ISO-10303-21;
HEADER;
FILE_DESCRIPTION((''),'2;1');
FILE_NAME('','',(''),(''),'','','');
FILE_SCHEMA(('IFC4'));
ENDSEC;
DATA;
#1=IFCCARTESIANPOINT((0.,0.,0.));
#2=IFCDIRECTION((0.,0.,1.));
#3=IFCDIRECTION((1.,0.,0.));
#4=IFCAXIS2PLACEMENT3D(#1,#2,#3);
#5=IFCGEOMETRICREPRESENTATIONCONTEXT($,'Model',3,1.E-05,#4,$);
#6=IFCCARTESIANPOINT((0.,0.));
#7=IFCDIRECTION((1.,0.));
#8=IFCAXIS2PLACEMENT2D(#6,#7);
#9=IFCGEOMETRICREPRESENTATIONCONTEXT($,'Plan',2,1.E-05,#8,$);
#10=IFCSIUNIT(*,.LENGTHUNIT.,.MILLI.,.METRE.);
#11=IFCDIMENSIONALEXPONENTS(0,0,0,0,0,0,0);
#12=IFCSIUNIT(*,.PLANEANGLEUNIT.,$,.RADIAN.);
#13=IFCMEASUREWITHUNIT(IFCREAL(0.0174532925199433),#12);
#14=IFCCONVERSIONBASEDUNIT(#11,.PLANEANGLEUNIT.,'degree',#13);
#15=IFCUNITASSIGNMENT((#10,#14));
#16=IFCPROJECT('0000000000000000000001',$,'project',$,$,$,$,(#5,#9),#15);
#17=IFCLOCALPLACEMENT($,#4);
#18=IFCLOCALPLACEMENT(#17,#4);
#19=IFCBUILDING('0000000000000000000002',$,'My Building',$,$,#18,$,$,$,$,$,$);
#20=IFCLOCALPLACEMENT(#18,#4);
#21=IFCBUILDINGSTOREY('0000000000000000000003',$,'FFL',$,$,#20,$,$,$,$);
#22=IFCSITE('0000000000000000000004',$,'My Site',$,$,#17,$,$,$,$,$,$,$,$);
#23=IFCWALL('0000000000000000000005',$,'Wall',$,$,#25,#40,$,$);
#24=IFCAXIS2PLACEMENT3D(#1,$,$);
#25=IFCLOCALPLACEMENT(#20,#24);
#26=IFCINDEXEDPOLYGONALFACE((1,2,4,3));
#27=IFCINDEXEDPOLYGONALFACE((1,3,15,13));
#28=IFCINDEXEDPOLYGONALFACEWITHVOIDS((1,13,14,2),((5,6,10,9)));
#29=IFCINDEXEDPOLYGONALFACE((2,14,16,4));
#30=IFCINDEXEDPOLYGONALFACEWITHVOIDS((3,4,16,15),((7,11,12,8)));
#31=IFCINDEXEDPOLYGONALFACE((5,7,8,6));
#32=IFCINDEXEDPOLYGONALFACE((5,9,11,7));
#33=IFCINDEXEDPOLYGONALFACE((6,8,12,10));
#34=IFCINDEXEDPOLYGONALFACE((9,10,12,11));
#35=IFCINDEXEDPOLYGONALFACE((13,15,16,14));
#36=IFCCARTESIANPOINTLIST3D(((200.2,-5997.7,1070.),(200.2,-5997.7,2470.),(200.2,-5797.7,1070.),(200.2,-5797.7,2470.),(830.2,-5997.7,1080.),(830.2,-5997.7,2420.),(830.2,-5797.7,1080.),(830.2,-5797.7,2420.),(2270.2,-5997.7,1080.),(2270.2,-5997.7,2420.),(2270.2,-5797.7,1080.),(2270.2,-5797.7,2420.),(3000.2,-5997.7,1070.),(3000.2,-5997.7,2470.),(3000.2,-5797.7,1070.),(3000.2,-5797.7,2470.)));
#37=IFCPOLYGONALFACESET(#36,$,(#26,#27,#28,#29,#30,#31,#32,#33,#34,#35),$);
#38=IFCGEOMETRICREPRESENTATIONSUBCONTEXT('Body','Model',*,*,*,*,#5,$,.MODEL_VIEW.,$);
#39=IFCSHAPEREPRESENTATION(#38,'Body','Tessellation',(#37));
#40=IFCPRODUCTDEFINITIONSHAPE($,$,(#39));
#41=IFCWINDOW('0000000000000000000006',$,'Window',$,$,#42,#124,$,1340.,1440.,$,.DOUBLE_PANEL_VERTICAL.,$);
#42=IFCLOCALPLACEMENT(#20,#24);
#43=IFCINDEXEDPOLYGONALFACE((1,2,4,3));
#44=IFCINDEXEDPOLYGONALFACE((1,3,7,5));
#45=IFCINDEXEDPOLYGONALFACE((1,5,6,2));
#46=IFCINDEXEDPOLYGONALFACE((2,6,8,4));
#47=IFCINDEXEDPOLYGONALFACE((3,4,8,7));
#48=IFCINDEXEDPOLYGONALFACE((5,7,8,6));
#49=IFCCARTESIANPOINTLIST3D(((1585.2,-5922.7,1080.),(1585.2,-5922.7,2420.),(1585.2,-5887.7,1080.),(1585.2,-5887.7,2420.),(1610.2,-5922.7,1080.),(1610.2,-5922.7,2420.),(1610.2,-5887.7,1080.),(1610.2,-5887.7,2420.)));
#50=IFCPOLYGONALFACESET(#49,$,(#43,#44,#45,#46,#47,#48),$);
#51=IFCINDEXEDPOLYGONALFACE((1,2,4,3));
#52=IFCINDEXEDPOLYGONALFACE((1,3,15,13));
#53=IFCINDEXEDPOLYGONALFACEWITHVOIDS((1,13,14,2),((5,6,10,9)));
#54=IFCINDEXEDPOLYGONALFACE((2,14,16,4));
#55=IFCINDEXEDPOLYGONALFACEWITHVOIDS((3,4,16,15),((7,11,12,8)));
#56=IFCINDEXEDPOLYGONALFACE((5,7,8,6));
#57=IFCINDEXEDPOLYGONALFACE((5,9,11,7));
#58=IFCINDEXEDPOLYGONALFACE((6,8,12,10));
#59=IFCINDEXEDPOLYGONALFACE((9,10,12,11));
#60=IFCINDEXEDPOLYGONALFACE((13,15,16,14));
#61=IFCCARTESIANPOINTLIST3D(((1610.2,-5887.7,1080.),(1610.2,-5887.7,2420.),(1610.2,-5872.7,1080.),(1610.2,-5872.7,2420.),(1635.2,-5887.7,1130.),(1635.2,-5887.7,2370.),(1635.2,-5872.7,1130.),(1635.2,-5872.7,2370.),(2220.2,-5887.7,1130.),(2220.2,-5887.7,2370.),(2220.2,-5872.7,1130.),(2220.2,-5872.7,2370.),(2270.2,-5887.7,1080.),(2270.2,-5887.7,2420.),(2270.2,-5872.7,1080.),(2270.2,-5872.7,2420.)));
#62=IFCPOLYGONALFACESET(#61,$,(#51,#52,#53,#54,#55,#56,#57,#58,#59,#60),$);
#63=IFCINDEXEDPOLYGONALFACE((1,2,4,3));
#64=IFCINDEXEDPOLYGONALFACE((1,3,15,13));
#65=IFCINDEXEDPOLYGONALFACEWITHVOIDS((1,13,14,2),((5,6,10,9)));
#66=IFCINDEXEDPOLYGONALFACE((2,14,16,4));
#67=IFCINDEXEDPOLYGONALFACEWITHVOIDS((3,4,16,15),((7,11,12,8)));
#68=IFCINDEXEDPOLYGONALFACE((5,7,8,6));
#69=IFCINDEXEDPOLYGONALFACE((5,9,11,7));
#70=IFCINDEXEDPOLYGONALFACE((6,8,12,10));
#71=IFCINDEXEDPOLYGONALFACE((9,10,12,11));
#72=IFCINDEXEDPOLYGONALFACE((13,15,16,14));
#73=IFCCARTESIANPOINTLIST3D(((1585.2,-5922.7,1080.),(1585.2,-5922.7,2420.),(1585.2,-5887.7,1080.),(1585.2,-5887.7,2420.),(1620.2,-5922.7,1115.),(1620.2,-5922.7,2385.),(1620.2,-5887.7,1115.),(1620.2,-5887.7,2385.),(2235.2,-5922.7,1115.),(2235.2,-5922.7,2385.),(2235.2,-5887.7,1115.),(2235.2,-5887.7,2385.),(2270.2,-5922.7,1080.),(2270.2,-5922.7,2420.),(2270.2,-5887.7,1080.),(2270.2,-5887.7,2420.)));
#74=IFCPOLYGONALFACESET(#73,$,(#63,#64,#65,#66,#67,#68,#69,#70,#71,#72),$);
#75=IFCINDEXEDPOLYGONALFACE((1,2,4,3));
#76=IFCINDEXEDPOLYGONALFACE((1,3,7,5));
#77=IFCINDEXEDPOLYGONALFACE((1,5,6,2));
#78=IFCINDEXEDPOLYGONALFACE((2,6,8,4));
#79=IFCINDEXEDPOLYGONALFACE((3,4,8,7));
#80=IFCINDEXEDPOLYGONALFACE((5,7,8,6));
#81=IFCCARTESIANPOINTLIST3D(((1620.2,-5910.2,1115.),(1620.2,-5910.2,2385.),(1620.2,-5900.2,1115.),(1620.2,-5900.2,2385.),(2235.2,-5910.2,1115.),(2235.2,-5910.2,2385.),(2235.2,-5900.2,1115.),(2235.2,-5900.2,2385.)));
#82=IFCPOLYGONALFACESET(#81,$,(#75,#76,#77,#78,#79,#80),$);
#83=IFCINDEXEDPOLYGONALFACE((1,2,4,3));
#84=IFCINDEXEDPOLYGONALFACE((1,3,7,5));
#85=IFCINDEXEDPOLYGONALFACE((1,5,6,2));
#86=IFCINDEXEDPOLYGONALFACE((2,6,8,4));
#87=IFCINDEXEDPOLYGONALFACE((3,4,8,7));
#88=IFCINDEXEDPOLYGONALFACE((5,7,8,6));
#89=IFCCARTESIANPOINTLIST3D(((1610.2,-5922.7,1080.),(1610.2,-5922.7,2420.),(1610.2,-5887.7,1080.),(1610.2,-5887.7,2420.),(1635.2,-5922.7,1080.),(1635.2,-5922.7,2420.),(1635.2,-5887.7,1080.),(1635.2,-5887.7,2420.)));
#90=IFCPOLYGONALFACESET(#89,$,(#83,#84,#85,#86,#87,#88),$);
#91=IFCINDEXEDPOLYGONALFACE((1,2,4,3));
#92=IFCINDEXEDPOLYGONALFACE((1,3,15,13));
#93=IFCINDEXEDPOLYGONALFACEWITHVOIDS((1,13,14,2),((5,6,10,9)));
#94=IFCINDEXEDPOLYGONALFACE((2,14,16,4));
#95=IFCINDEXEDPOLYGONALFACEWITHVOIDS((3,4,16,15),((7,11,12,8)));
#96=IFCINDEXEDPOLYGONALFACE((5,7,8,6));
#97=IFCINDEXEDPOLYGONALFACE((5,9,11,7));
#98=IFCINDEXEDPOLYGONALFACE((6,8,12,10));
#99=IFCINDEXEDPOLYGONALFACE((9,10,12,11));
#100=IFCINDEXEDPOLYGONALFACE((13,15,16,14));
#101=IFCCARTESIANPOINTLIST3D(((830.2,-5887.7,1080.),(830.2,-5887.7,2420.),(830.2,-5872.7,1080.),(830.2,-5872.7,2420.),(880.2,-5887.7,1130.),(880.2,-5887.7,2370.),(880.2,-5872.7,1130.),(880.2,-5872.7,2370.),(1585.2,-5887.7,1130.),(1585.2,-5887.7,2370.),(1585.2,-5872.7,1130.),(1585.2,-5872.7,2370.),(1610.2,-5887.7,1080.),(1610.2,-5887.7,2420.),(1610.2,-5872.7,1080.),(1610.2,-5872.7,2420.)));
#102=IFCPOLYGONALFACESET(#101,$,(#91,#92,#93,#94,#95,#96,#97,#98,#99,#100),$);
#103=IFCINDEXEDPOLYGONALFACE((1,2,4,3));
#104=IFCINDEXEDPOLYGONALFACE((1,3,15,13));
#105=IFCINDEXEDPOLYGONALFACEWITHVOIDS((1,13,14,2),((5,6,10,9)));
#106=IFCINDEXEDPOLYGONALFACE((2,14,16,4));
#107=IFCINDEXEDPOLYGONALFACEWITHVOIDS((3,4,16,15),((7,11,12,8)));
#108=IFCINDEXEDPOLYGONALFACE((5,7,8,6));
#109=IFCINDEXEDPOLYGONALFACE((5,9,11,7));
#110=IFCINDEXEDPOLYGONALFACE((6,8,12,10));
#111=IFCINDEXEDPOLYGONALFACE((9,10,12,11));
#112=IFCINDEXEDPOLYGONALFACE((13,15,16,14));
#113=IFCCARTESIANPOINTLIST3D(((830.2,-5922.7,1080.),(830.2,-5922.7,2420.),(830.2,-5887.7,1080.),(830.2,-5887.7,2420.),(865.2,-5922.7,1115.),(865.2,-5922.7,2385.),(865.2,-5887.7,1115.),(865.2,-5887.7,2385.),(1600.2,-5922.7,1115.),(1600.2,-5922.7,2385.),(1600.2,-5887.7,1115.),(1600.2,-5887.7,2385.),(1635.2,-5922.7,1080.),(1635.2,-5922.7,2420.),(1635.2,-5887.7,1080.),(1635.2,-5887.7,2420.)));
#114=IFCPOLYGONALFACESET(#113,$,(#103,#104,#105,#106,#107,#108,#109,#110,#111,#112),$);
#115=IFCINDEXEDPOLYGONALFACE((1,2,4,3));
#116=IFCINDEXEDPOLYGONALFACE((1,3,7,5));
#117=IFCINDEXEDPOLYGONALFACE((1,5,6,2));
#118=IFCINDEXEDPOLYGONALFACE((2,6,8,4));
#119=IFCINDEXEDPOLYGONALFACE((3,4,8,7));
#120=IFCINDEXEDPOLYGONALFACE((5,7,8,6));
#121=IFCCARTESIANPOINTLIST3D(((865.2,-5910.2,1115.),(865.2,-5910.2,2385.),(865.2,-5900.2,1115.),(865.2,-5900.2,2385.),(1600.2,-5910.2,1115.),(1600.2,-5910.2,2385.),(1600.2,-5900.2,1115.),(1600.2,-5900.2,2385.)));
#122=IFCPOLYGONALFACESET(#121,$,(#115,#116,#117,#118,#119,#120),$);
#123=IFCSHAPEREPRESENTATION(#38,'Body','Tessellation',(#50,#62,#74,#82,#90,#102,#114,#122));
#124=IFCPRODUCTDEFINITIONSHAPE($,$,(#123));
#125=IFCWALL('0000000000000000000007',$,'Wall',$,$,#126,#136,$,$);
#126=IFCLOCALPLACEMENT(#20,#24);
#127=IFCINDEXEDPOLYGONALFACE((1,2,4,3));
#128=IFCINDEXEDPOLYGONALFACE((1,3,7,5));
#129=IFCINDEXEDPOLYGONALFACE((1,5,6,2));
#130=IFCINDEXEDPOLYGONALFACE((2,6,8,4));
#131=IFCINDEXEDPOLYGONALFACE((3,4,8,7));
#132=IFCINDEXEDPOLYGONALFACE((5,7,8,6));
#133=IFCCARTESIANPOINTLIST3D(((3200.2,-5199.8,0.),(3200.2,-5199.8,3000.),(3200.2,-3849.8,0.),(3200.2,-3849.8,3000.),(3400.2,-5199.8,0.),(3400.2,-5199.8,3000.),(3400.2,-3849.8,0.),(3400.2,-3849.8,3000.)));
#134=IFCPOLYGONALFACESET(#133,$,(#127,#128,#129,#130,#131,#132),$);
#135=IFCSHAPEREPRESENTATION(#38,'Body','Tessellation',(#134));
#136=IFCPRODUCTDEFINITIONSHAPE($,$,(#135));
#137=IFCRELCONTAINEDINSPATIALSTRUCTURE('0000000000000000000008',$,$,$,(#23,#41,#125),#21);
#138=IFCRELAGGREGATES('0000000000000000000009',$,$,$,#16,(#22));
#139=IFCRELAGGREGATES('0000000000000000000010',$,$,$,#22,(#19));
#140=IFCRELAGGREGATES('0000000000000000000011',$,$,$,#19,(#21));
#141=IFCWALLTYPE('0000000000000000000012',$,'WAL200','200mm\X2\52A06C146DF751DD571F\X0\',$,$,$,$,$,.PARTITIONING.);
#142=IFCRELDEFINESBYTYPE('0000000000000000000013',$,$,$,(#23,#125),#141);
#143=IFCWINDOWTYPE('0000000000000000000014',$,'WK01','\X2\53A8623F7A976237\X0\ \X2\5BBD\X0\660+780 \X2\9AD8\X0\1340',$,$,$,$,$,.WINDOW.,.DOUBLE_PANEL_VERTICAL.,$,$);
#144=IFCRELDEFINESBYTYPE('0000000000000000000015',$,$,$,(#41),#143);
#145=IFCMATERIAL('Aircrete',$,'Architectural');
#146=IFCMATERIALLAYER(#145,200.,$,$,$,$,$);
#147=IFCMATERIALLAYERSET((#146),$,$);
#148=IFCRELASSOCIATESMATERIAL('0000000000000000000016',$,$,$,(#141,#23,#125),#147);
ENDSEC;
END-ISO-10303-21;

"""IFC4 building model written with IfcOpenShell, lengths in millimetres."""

from ifc_helpers import new_model, entity, si_unit, converted_unit, frame, origin_with_axes, origin_2d_with_axis, place, context, subcontext, project, spatial, line, indexed_curve, outline, extrude, shape, source, transform, mapped, material, layer, layer_set, layer_usage, type_object, type_shapes, element, fill, save


model = new_model("IFC4")

# Units and contexts
model_context = context("Model", 3, precision=1e-05, world=origin_with_axes())
plan_context = context("Plan", 2, precision=1e-05, world=origin_2d_with_axis())
body_context_1 = subcontext(model_context, "Body", "Model", "MODEL_VIEW")
body_context_2 = subcontext(plan_context, "Body", "Plan", "PLAN_VIEW")
ifc_project = project(units=[si_unit("LENGTHUNIT", "METRE", prefix="MILLI"), converted_unit("PLANEANGLEUNIT", "degree", entity("IfcReal", 0.0174532925199433), si_unit("PLANEANGLEUNIT", "RADIAN"), dimensions=[0, 0, 0, 0, 0, 0, 0])], contexts=[model_context, plan_context])

# Site, building, storey
site_placement = place(None, origin_with_axes())
site = spatial("IfcSite", under=ifc_project, at=site_placement, Name="My Site")
building_placement = place(site_placement, origin_with_axes())
building = spatial("IfcBuilding", under=site, at=building_placement, Name="My Building")
storey_placement = place(building_placement, origin_with_axes())
storey = spatial("IfcBuildingStorey", under=building, at=storey_placement, Name="FFL")

# Shared definitions
ifc_material_1 = material(Name="Aircrete", Category="Architectural")

# Wall, opening, window
ifc_layer_1 = layer(ifc_material_1, 200.0)
ifc_layer_set_1 = layer_set([ifc_layer_1])
ifc_layer_usage_1 = layer_usage(ifc_layer_set_1, "AXIS2", "NEGATIVE", 0.0)
wall_type_1 = type_object("IfcWallType", Name="WAL200", Description="200mm加气混凝土", PredefinedType="PARTITIONING", material=ifc_layer_set_1)
wall_1_placement = place(storey_placement, frame((200.2, -5797.7, 1070.0), z_axis=(0.0, 0.0, 1.0), x_axis=(1.0, 0.0, 0.0)))
wall_1 = element("IfcWall", 1, at=wall_1_placement, inside=storey, type_object=wall_type_1, material=ifc_layer_usage_1, Name="Wall", context=body_context_1, shape_type="SweptSolid", body=[
    extrude(outline(indexed_curve([(0.0, -200.0), (0.0, 0.0), (2800.0, 0.0), (2800.0, -200.0)], segments=[line(1, 2, 3, 4, 1)])), origin_with_axes(), (0.0, 0.0, 1.0), 1400.0),
])
shared_shape_1 = source(origin_with_axes(), body_context_1, "Body", "SweptSolid", [
    extrude(outline(indexed_curve([(0.0, 0.0), (1440.0, 0.0), (1440.0, 1340.0), (0.0, 1340.0)], segments=[line(1, 2, 3, 4, 1)])), frame((0.0, -600.0, 0.0), z_axis=(0.0, -1.0, 0.0), x_axis=(1.0, 0.0, 0.0)), (0.0, 0.0, -1.0), 1200.0),
])
opening_1_placement = place(wall_1_placement, frame((2070.0, -25.0, 10.0), z_axis=(0.0, 0.0, 1.0), x_axis=(-1.0, 0.0, 0.0)))
opening_1 = element("IfcOpeningElement", 2, at=opening_1_placement, cuts=wall_1, PredefinedType="OPENING", context=body_context_1, shape_type="MappedRepresentation", body=[
    mapped(shared_shape_1, transform((0.0, 0.0, 0.0), x_axis=(1.0, 0.0, 0.0), y_axis=(0.0, 1.0, 0.0), z_axis=(0.0, 0.0, 1.0), scale=1.0)),
])
window_type_1 = type_object("IfcWindowType", Name="WK01", Description="厨房窗户 宽660+780 高1340", PartitioningType="DOUBLE_PANEL_VERTICAL", PredefinedType="WINDOW")
shared_shape_2 = source(origin_with_axes(), body_context_1, "Body", "SweptSolid", [
    extrude(outline(indexed_curve([(660.0, 1340.0), (660.0, 0.0), (685.0, 0.0), (685.0, 1340.0)], segments=[line(1, 2, 3, 4, 1)])), frame((0.0, 65.0, 0.0), z_axis=(0.0, -1.0, 0.0), x_axis=(1.0, 0.0, 0.0)), (0.0, 0.0, -1.0), 35.0),
    extrude(outline(indexed_curve([(0.0, 0.0), (660.0, 0.0), (660.0, 1340.0), (0.0, 1340.0)], segments=[line(1, 2, 3, 4, 1)]), holes=[indexed_curve([(50.0, 50.0), (635.0, 50.0), (635.0, 1290.0), (50.0, 1290.0)], segments=[line(1, 2, 3, 4, 1)])]), frame((0.0, 50.0, 0.0), z_axis=(0.0, -1.0, 0.0), x_axis=(1.0, 0.0, 0.0)), (0.0, 0.0, -1.0), 15.0),
    extrude(outline(indexed_curve([(0.0, 0.0), (685.0, 0.0), (685.0, 1340.0), (0.0, 1340.0)], segments=[line(1, 2, 3, 4, 1)]), holes=[indexed_curve([(35.0, 35.0), (650.0, 35.0), (650.0, 1305.0), (35.0, 1305.0)], segments=[line(1, 2, 3, 4, 1)])]), frame((0.0, 65.0, 0.0), z_axis=(0.0, -1.0, 0.0), x_axis=(1.0, 0.0, 0.0)), (0.0, 0.0, -1.0), 35.0),
    extrude(outline(indexed_curve([(35.0, 35.0), (650.0, 35.0), (650.0, 1305.0), (35.0, 1305.0)], segments=[line(1, 2, 3, 4, 1)])), frame((0.0, 77.5, 0.0), z_axis=(0.0, -1.0, 0.0), x_axis=(1.0, 0.0, 0.0)), (0.0, 0.0, -1.0), 10.0),
    extrude(outline(indexed_curve([(0.0, 0.0), (0.0, 1340.0), (-25.0, 1340.0), (-25.0, 0.0)], segments=[line(1, 2, 3, 4, 1)])), frame((660.0, 65.0, 0.0), z_axis=(0.0, -1.0, 0.0), x_axis=(1.0, 0.0, 0.0)), (0.0, 0.0, -1.0), 35.0),
    extrude(outline(indexed_curve([(0.0, 0.0), (780.0, 0.0), (780.0, 1340.0), (0.0, 1340.0)], segments=[line(1, 2, 3, 4, 1)]), holes=[indexed_curve([(25.0, 50.0), (730.0, 50.0), (730.0, 1290.0), (25.0, 1290.0)], segments=[line(1, 2, 3, 4, 1)])]), frame((660.0, 50.0, 0.0), z_axis=(0.0, -1.0, 0.0), x_axis=(1.0, 0.0, 0.0)), (0.0, 0.0, -1.0), 15.0),
    extrude(outline(indexed_curve([(0.0, 1340.0), (805.0, 1340.0), (805.0, 0.0), (0.0, 0.0), (0.0, 1340.0)]), holes=[indexed_curve([(35.0, 1305.0), (770.0, 1305.0), (770.0, 35.0), (35.0, 35.0), (35.0, 1305.0)])]), frame((635.0, 65.0, 0.0), z_axis=(0.0, -1.0, 0.0), x_axis=(1.0, 0.0, 0.0)), (0.0, 0.0, -1.0), 35.0),
    extrude(outline(indexed_curve([(35.0, 35.0), (770.0, 35.0), (770.0, 1305.0), (35.0, 1305.0)], segments=[line(1, 2, 3, 4, 1)])), frame((635.0, 77.5, 0.0), z_axis=(0.0, -1.0, 0.0), x_axis=(1.0, 0.0, 0.0)), (0.0, 0.0, -1.0), 10.0),
])
shared_shape_3 = source(origin_with_axes(), body_context_2, "Body", "Curve2D", [
    entity("IfcIndexedPolyCurve", entity("IfcCartesianPointList2D", [[50.0, 50.0], [635.0, 50.0]])),
    entity("IfcIndexedPolyCurve", entity("IfcCartesianPointList2D", [[0.0, 100.0], [0.0, 100.0], [0.0, 65.0], [50.0, 65.0], [50.0, 50.0], [0.0, 50.0]]), [entity("IfcLineIndex", [1, 2, 3, 4, 5, 6, 1])]),
    entity("IfcIndexedPolyCurve", entity("IfcCartesianPointList2D", [[660.0, 100.0], [685.0, 100.0], [685.0, 65.0], [635.0, 65.0], [635.0, 50.0], [660.0, 50.0]])),
    entity("IfcIndexedPolyCurve", entity("IfcCartesianPointList2D", [[0.0, 65.0], [35.0, 65.0], [35.0, 100.0], [0.0, 100.0]]), [entity("IfcLineIndex", [1, 2, 3, 4, 1])]),
    entity("IfcIndexedPolyCurve", entity("IfcCartesianPointList2D", [[685.0, 65.0], [650.0, 65.0], [650.0, 100.0], [685.0, 100.0]]), [entity("IfcLineIndex", [1, 2, 3, 4, 1])]),
    entity("IfcIndexedPolyCurve", entity("IfcCartesianPointList2D", [[35.0, 65.0], [650.0, 65.0]])),
    entity("IfcIndexedPolyCurve", entity("IfcCartesianPointList2D", [[35.0, 100.0], [650.0, 100.0]])),
    entity("IfcIndexedPolyCurve", entity("IfcCartesianPointList2D", [[35.0, 82.5], [650.0, 82.5]])),
    entity("IfcIndexedPolyCurve", entity("IfcCartesianPointList2D", [[685.0, 50.0], [1390.0, 50.0]])),
    entity("IfcIndexedPolyCurve", entity("IfcCartesianPointList2D", [[660.0, 100.0], [635.0, 100.0], [635.0, 65.0], [685.0, 65.0], [685.0, 50.0], [660.0, 50.0]])),
    entity("IfcIndexedPolyCurve", entity("IfcCartesianPointList2D", [[1440.0, 100.0], [1440.0, 100.0], [1440.0, 65.0], [1390.0, 65.0], [1390.0, 50.0], [1440.0, 50.0]]), [entity("IfcLineIndex", [1, 2, 3, 4, 5, 6, 1])]),
    entity("IfcIndexedPolyCurve", entity("IfcCartesianPointList2D", [[635.0, 65.0], [670.0, 65.0], [670.0, 100.0], [635.0, 100.0]]), [entity("IfcLineIndex", [1, 2, 3, 4, 1])]),
    entity("IfcIndexedPolyCurve", entity("IfcCartesianPointList2D", [[1440.0, 65.0], [1405.0, 65.0], [1405.0, 100.0], [1440.0, 100.0]]), [entity("IfcLineIndex", [1, 2, 3, 4, 1])]),
    entity("IfcIndexedPolyCurve", entity("IfcCartesianPointList2D", [[670.0, 65.0], [1405.0, 65.0]])),
    entity("IfcIndexedPolyCurve", entity("IfcCartesianPointList2D", [[670.0, 100.0], [1405.0, 100.0]])),
    entity("IfcIndexedPolyCurve", entity("IfcCartesianPointList2D", [[670.0, 82.5], [1405.0, 82.5]])),
])
type_shapes(window_type_1, [shared_shape_2, shared_shape_3])
window_1_placement = place(opening_1_placement, frame((0.0, 0.0, 0.0), z_axis=(0.0, 0.0, 1.0), x_axis=(1.0, 0.0, 0.0)))
window_1 = element("IfcWindow", 3, at=window_1_placement, inside=storey, type_object=window_type_1, Name="Window", OverallHeight=1340.0, OverallWidth=1440.0, PartitioningType="DOUBLE_PANEL_VERTICAL", shapes=[
    shape(body_context_1, "Body", "MappedRepresentation", [mapped(shared_shape_2, transform((0.0, 0.0, 0.0), x_axis=(1.0, 0.0, 0.0), y_axis=(0.0, 1.0, 0.0), z_axis=(0.0, 0.0, 1.0), scale=1.0))]),
    shape(body_context_2, "Body", "MappedRepresentation", [mapped(shared_shape_3, transform((0.0, 0.0, 0.0), x_axis=(1.0, 0.0, 0.0), y_axis=(0.0, 1.0, 0.0), z_axis=(0.0, 0.0, 1.0), scale=1.0))]),
])
fill(opening_1, window_1)

# Wall
ifc_layer_usage_2 = layer_usage(ifc_layer_set_1, "AXIS2", "NEGATIVE", 0.0)
wall_2_placement = place(storey_placement, frame((3200.2, -5199.8, 0.0), z_axis=(0.0, 0.0, 1.0), x_axis=(-0.000007, 1.0, 0.0)))
element("IfcWall", 4, at=wall_2_placement, inside=storey, type_object=wall_type_1, material=ifc_layer_usage_2, Name="Wall", context=body_context_1, shape_type="SweptSolid", body=[
    extrude(outline(indexed_curve([(0.0, -200.0), (0.0, 0.0), (1350.0, 0.0), (1350.0, -200.0)], segments=[line(1, 2, 3, 4, 1)])), origin_with_axes(), (0.0, 0.0, 1.0), 3000.0),
])

save(model, "model.ifc")
